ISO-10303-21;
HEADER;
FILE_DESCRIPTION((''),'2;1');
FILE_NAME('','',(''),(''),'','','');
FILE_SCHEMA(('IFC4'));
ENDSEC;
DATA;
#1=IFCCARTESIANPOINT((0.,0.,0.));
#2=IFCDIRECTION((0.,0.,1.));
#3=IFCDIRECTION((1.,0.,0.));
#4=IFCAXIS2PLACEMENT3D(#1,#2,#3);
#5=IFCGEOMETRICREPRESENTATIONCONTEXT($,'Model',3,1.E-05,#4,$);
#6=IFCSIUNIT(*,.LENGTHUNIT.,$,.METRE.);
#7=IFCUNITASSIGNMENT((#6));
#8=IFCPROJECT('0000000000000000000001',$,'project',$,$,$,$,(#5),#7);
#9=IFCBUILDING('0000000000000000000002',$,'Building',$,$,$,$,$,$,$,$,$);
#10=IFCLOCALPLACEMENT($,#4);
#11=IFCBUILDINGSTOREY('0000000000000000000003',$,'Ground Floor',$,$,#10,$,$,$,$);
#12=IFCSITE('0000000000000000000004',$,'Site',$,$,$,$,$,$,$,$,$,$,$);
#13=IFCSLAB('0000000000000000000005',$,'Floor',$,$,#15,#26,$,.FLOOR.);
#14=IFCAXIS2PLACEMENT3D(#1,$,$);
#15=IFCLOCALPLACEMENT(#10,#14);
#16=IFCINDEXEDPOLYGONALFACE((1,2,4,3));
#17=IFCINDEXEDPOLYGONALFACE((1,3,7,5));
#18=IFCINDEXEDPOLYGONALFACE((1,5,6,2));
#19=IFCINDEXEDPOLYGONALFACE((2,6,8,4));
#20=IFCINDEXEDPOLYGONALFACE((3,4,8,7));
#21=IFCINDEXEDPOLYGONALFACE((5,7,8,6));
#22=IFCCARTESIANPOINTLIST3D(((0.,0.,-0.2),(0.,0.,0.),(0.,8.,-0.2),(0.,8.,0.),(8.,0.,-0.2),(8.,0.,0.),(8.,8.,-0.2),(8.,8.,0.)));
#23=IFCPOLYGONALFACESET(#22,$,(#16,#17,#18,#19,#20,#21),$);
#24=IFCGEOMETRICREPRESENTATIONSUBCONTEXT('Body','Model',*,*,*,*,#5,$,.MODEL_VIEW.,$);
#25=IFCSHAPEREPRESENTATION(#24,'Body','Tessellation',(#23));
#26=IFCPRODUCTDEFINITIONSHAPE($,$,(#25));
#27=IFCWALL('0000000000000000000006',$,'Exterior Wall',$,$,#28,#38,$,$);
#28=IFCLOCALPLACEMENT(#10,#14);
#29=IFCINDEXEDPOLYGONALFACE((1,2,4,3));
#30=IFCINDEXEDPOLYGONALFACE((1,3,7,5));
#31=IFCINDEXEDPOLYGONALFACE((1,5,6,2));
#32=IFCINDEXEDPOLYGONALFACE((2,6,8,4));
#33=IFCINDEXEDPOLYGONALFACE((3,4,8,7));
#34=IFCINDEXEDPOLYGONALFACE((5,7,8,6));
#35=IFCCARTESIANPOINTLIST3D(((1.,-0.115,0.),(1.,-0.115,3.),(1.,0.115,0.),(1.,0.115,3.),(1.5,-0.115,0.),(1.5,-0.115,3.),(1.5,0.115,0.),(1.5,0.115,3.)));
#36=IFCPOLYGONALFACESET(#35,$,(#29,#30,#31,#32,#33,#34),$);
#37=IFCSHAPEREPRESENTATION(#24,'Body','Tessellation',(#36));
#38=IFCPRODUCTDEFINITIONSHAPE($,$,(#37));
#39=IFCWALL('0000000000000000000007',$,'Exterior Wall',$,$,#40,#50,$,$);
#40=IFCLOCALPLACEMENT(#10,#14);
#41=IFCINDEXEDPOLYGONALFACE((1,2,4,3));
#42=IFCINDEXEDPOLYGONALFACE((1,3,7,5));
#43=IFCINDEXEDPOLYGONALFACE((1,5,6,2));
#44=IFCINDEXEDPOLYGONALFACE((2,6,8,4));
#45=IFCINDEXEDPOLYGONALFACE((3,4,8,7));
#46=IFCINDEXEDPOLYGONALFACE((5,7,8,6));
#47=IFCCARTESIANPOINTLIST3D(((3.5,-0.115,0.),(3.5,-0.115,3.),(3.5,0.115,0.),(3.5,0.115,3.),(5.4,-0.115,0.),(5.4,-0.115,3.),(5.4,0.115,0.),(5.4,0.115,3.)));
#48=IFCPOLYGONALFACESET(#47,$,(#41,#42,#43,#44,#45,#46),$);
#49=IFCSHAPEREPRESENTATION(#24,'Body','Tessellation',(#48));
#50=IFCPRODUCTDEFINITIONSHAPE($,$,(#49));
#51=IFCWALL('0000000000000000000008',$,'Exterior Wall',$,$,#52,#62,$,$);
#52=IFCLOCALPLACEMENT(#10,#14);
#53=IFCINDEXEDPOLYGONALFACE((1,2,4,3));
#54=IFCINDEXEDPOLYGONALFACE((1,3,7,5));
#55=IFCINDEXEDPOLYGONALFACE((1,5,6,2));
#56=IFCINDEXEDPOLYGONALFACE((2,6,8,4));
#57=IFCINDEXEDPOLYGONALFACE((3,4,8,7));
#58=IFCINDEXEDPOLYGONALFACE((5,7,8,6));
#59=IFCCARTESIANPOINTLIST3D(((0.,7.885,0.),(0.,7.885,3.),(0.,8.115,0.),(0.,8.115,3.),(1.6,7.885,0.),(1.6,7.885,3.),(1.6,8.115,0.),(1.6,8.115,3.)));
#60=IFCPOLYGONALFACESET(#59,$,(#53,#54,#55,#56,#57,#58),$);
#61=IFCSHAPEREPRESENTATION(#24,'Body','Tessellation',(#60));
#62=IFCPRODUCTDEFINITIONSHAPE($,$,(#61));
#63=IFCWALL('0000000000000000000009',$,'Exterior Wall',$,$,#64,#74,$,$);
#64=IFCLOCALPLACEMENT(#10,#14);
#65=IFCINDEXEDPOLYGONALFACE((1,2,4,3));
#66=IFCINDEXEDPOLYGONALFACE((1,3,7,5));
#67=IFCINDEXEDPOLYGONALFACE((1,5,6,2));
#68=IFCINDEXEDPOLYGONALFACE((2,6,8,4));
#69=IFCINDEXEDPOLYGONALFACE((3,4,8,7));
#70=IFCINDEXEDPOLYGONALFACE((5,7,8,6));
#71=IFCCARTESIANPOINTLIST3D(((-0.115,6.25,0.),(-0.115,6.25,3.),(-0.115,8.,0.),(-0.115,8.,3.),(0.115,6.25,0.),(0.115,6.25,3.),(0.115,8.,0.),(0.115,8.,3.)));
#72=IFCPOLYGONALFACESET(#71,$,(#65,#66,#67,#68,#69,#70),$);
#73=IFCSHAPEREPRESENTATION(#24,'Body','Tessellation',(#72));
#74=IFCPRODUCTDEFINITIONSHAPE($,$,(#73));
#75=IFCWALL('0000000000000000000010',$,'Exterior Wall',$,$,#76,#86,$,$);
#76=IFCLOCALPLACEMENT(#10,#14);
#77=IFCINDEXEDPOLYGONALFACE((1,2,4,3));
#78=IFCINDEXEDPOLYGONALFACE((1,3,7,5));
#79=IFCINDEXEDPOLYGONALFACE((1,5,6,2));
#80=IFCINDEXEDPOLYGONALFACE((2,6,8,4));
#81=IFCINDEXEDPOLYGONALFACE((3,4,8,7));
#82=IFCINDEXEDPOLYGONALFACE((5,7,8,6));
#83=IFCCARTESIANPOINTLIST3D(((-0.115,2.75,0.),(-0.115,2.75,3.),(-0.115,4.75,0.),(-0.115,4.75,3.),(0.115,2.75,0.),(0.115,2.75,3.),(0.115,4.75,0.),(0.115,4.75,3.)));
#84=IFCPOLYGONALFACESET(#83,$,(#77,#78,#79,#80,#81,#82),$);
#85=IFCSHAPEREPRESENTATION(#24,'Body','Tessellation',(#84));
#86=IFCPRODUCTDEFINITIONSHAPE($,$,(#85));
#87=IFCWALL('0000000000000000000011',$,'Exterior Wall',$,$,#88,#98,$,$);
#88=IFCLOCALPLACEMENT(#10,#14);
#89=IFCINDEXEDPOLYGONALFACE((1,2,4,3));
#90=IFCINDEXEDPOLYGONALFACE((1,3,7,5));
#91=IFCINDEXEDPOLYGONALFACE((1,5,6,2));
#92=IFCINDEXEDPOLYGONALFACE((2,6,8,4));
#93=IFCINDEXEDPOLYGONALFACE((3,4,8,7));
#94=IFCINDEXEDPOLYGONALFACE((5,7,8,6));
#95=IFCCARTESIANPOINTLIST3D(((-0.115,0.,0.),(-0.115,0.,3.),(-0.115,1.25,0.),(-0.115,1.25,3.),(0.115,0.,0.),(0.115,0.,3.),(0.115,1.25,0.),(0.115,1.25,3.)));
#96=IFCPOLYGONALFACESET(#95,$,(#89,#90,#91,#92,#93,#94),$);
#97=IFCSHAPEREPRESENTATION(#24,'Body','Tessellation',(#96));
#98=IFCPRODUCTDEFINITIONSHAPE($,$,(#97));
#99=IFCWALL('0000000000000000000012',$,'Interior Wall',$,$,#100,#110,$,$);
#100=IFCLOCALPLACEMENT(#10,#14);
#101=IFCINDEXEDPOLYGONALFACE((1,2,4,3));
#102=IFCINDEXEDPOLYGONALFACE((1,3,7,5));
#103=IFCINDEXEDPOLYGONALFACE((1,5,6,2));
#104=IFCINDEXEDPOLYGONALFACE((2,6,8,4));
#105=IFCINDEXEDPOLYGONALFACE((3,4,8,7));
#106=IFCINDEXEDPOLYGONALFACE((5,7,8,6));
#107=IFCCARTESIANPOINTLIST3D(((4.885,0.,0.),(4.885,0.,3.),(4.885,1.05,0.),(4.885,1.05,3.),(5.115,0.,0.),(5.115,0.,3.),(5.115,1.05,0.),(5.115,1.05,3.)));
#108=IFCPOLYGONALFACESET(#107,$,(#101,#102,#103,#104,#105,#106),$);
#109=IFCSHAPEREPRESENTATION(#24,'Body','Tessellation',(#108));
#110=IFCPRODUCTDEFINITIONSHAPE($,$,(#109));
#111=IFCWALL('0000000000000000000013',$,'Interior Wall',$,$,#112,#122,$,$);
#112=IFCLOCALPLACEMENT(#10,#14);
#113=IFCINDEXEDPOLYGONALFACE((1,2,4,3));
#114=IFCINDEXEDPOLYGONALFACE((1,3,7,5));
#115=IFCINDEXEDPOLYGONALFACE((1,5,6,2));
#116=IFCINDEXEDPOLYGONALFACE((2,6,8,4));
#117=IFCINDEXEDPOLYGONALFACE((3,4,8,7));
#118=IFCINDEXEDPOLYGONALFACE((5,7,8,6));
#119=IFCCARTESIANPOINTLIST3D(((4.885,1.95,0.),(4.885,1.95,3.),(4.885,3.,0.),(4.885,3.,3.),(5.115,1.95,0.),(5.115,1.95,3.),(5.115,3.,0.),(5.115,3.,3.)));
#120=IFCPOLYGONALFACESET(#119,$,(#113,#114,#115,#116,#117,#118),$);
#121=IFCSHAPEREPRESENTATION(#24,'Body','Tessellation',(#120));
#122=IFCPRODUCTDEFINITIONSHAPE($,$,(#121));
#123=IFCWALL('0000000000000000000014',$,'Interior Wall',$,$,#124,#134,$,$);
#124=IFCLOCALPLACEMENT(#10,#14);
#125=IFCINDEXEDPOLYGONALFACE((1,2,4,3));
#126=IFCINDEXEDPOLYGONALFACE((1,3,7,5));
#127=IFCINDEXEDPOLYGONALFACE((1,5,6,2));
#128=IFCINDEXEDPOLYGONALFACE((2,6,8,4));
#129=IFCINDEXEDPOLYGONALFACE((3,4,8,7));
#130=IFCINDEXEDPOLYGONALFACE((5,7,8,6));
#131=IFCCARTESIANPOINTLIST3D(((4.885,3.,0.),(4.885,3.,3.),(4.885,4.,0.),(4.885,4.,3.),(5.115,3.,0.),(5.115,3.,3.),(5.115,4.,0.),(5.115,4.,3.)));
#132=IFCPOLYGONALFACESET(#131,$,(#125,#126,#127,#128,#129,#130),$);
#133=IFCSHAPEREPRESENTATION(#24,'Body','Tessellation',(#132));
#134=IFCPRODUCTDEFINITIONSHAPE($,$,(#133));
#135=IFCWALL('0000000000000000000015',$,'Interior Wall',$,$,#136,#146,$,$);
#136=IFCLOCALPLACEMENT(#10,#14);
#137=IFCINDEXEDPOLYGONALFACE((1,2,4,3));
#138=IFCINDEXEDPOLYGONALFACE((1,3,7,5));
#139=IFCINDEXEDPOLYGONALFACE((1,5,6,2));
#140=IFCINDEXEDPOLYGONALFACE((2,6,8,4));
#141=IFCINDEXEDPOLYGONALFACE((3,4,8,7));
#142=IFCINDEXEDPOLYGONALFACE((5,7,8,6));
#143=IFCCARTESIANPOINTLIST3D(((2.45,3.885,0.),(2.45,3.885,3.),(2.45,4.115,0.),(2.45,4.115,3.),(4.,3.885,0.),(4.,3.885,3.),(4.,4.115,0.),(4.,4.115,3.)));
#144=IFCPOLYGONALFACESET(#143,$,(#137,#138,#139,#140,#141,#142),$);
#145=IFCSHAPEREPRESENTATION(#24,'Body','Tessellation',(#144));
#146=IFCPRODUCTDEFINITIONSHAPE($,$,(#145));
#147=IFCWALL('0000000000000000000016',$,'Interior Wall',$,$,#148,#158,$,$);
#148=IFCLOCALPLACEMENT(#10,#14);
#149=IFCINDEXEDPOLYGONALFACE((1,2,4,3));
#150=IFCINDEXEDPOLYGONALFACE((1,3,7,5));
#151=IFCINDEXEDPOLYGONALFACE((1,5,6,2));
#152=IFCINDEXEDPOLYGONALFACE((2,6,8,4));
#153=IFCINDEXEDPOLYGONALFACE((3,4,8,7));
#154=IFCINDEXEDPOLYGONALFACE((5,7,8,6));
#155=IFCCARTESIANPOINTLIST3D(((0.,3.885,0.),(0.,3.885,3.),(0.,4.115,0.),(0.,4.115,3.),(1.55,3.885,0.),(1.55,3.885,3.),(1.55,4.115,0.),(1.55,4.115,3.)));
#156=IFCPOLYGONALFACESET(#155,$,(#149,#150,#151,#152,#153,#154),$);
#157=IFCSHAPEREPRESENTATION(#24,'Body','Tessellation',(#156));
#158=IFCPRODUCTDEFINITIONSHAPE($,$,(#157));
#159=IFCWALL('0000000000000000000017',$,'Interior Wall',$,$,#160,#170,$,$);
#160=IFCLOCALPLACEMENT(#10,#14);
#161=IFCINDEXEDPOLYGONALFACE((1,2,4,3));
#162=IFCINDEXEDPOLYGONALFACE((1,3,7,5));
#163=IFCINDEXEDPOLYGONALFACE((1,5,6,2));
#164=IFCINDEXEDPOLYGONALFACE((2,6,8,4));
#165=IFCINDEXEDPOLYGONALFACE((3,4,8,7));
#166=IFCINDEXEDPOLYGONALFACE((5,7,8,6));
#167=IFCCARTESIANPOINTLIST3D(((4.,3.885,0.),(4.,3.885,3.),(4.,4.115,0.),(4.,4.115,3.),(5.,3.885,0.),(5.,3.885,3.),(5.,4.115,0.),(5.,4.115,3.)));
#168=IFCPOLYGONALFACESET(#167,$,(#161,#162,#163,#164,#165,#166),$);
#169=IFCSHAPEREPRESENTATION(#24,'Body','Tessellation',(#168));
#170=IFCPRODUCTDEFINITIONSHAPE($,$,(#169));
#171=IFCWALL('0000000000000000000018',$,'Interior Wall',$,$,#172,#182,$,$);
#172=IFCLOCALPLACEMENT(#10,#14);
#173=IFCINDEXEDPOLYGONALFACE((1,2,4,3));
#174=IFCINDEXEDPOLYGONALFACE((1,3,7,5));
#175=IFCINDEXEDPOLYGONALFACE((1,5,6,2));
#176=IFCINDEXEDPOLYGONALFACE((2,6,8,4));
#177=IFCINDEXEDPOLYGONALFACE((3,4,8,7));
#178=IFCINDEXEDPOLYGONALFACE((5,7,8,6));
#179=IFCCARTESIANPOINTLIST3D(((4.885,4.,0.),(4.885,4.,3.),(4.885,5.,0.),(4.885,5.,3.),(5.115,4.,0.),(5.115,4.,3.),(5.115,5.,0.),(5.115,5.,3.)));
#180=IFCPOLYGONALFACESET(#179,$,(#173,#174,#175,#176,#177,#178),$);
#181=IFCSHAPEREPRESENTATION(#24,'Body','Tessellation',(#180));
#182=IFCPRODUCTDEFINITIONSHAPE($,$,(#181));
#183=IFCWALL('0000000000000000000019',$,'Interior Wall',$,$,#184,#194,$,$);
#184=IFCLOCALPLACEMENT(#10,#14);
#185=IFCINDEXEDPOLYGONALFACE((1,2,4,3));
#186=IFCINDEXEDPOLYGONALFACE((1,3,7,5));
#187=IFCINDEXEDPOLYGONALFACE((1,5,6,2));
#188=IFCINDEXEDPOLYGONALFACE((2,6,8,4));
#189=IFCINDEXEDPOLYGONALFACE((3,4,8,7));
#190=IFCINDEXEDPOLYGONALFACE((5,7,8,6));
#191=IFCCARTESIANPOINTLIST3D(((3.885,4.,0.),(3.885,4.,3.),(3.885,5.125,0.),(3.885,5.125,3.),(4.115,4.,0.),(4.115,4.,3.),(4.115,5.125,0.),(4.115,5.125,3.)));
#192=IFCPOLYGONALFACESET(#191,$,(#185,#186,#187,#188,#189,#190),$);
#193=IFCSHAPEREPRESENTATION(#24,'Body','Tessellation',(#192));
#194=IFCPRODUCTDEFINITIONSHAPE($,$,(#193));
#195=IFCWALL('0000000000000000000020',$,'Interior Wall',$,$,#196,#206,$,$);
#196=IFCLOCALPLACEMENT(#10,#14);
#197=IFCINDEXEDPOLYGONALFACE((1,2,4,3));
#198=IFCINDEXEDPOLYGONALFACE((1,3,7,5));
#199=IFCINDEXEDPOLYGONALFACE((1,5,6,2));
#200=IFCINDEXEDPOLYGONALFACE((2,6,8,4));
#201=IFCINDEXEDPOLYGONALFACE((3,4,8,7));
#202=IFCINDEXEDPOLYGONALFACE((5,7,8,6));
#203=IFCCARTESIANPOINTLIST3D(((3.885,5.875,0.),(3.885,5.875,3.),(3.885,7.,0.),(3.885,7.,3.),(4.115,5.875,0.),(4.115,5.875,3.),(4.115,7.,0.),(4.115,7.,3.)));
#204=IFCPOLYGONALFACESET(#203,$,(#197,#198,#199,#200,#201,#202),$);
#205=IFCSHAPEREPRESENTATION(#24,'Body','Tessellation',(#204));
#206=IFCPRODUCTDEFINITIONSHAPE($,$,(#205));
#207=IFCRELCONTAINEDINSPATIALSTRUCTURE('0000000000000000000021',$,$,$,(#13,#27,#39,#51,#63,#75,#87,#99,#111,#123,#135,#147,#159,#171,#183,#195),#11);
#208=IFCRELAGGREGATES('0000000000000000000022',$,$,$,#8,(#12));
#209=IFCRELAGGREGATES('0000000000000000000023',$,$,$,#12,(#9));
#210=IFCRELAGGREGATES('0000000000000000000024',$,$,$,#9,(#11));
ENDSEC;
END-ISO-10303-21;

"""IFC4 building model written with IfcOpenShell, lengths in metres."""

from ifc_helpers import new_model, si_unit, frame, origin_with_axes, place, context, subcontext, project, spatial, indexed_curve, outline, extrude, element, save


model = new_model("IFC4")

# Units and contexts
model_context = context("Model", 3, precision=1e-05, world=origin_with_axes())
body_context = subcontext(model_context, "Body", "Model", "MODEL_VIEW")
ifc_project = project(units=[si_unit("LENGTHUNIT", "METRE")], contexts=[model_context])

# Site, building, storey
site = spatial("IfcSite", under=ifc_project, Name="Site")
building = spatial("IfcBuilding", under=site, Name="Building")
storey_placement = place(None, origin_with_axes())
storey = spatial("IfcBuildingStorey", under=building, at=storey_placement, Name="Ground Floor")

# Slab
slab_placement = place(storey_placement, frame((0.0, 0.0, -0.2), z_axis=(0.0, 0.0, 1.0), x_axis=(1.0, 0.0, 0.0)))
element("IfcSlab", 1, at=slab_placement, inside=storey, Name="Floor", PredefinedType="FLOOR", context=body_context, shape_type="SweptSolid", body=[
    extrude(outline(indexed_curve([(0.0, 0.0), (8.0, 0.0), (8.0, 8.0), (0.0, 8.0)])), None, (0.0, 0.0, 1.0), 0.2),
])

# Walls
wall_1_placement = place(storey_placement, frame((1.0, 0.0, 0.0), z_axis=(0.0, 0.0, 1.0), x_axis=(1.0, 0.0, 0.0)))
element("IfcWall", 2, at=wall_1_placement, inside=storey, Name="Exterior Wall", context=body_context, shape_type="SweptSolid", body=[
    extrude(outline(indexed_curve([(0.0, 0.0), (0.0, 0.23), (0.5, 0.23), (0.5, 0.0), (0.0, 0.0)], self_intersect=False)), frame((0.0, -0.115, 0.0), z_axis=(0.0, 0.0, 1.0), x_axis=(1.0, 0.0, 0.0)), (0.0, 0.0, 1.0), 3.0),
])
wall_2_placement = place(storey_placement, frame((3.5, 0.0, 0.0), z_axis=(0.0, 0.0, 1.0), x_axis=(1.0, 0.0, 0.0)))
element("IfcWall", 3, at=wall_2_placement, inside=storey, Name="Exterior Wall", context=body_context, shape_type="SweptSolid", body=[
    extrude(outline(indexed_curve([(0.0, 0.0), (0.0, 0.23), (1.9, 0.23), (1.9, 0.0), (0.0, 0.0)], self_intersect=False)), frame((0.0, -0.115, 0.0), z_axis=(0.0, 0.0, 1.0), x_axis=(1.0, 0.0, 0.0)), (0.0, 0.0, 1.0), 3.0),
])
wall_3_placement = place(storey_placement, frame((1.6, 8.0, 0.0), z_axis=(0.0, 0.0, 1.0), x_axis=(-1.0, 0.0, 0.0)))
element("IfcWall", 4, at=wall_3_placement, inside=storey, Name="Exterior Wall", context=body_context, shape_type="SweptSolid", body=[
    extrude(outline(indexed_curve([(0.0, 0.0), (0.0, 0.23), (1.6, 0.23), (1.6, 0.0), (0.0, 0.0)], self_intersect=False)), frame((0.0, -0.115, 0.0), z_axis=(0.0, 0.0, 1.0), x_axis=(1.0, 0.0, 0.0)), (0.0, 0.0, 1.0), 3.0),
])
wall_4_placement = place(storey_placement, frame((0.0, 8.0, 0.0), z_axis=(0.0, 0.0, 1.0), x_axis=(0.0, -1.0, 0.0)))
element("IfcWall", 5, at=wall_4_placement, inside=storey, Name="Exterior Wall", context=body_context, shape_type="SweptSolid", body=[
    extrude(outline(indexed_curve([(0.0, 0.0), (0.0, 0.23), (1.75, 0.23), (1.75, 0.0), (0.0, 0.0)], self_intersect=False)), frame((0.0, -0.115, 0.0), z_axis=(0.0, 0.0, 1.0), x_axis=(1.0, 0.0, 0.0)), (0.0, 0.0, 1.0), 3.0),
])
wall_5_placement = place(storey_placement, frame((0.0, 4.75, 0.0), z_axis=(0.0, 0.0, 1.0), x_axis=(0.0, -1.0, 0.0)))
element("IfcWall", 6, at=wall_5_placement, inside=storey, Name="Exterior Wall", context=body_context, shape_type="SweptSolid", body=[
    extrude(outline(indexed_curve([(0.0, 0.0), (0.0, 0.23), (2.0, 0.23), (2.0, 0.0), (0.0, 0.0)], self_intersect=False)), frame((0.0, -0.115, 0.0), z_axis=(0.0, 0.0, 1.0), x_axis=(1.0, 0.0, 0.0)), (0.0, 0.0, 1.0), 3.0),
])
wall_6_placement = place(storey_placement, frame((0.0, 1.25, 0.0), z_axis=(0.0, 0.0, 1.0), x_axis=(0.0, -1.0, 0.0)))
element("IfcWall", 7, at=wall_6_placement, inside=storey, Name="Exterior Wall", context=body_context, shape_type="SweptSolid", body=[
    extrude(outline(indexed_curve([(0.0, 0.0), (0.0, 0.23), (1.25, 0.23), (1.25, 0.0), (0.0, 0.0)], self_intersect=False)), frame((0.0, -0.115, 0.0), z_axis=(0.0, 0.0, 1.0), x_axis=(1.0, 0.0, 0.0)), (0.0, 0.0, 1.0), 3.0),
])
for number, where, z_axis, x_axis, name in (
    (8, (5.0, 0.0, 0.0), (0.0, 0.0, 1.0), (0.0, 1.0, 0.0), "Interior Wall"),
    (9, (5.0, 1.95, 0.0), (0.0, 0.0, 1.0), (0.0, 1.0, 0.0), "Interior Wall"),
):
    element("IfcWall", number, at=place(storey_placement, frame(where, z_axis=z_axis, x_axis=x_axis)), inside=storey, Name=name, context=body_context, shape_type="SweptSolid", body=[
        extrude(outline(indexed_curve([(0.0, 0.0), (0.0, 0.23), (1.05, 0.23), (1.05, 0.0), (0.0, 0.0)], self_intersect=False)), frame((0.0, -0.115, 0.0), z_axis=(0.0, 0.0, 1.0), x_axis=(1.0, 0.0, 0.0)), (0.0, 0.0, 1.0), 3.0),
    ])
wall_7_placement = place(storey_placement, frame((5.0, 3.0, 0.0), z_axis=(0.0, 0.0, 1.0), x_axis=(0.0, 1.0, 0.0)))
element("IfcWall", 10, at=wall_7_placement, inside=storey, Name="Interior Wall", context=body_context, shape_type="SweptSolid", body=[
    extrude(outline(indexed_curve([(0.0, 0.0), (0.0, 0.23), (1.0, 0.23), (1.0, 0.0), (0.0, 0.0)], self_intersect=False)), frame((0.0, -0.115, 0.0), z_axis=(0.0, 0.0, 1.0), x_axis=(1.0, 0.0, 0.0)), (0.0, 0.0, 1.0), 3.0),
])
for number, where, z_axis, x_axis, name in (
    (11, (4.0, 4.0, 0.0), (0.0, 0.0, 1.0), (-1.0, 0.0, 0.0), "Interior Wall"),
    (12, (1.55, 4.0, 0.0), (0.0, 0.0, 1.0), (-1.0, 0.0, 0.0), "Interior Wall"),
):
    element("IfcWall", number, at=place(storey_placement, frame(where, z_axis=z_axis, x_axis=x_axis)), inside=storey, Name=name, context=body_context, shape_type="SweptSolid", body=[
        extrude(outline(indexed_curve([(0.0, 0.0), (0.0, 0.23), (1.55, 0.23), (1.55, 0.0), (0.0, 0.0)], self_intersect=False)), frame((0.0, -0.115, 0.0), z_axis=(0.0, 0.0, 1.0), x_axis=(1.0, 0.0, 0.0)), (0.0, 0.0, 1.0), 3.0),
    ])
for number, where, z_axis, x_axis, name in (
    (13, (5.0, 4.0, 0.0), (0.0, 0.0, 1.0), (-1.0, 0.0, 0.0), "Interior Wall"),
    (14, (5.0, 5.0, 0.0), (0.0, 0.0, 1.0), (0.0, -1.0, 0.0), "Interior Wall"),
):
    element("IfcWall", number, at=place(storey_placement, frame(where, z_axis=z_axis, x_axis=x_axis)), inside=storey, Name=name, context=body_context, shape_type="SweptSolid", body=[
        extrude(outline(indexed_curve([(0.0, 0.0), (0.0, 0.23), (1.0, 0.23), (1.0, 0.0), (0.0, 0.0)], self_intersect=False)), frame((0.0, -0.115, 0.0), z_axis=(0.0, 0.0, 1.0), x_axis=(1.0, 0.0, 0.0)), (0.0, 0.0, 1.0), 3.0),
    ])
for number, where, z_axis, x_axis, name in (
    (15, (4.0, 4.0, 0.0), (0.0, 0.0, 1.0), (0.0, 1.0, 0.0), "Interior Wall"),
    (16, (4.0, 5.875, 0.0), (0.0, 0.0, 1.0), (0.0, 1.0, 0.0), "Interior Wall"),
):
    element("IfcWall", number, at=place(storey_placement, frame(where, z_axis=z_axis, x_axis=x_axis)), inside=storey, Name=name, context=body_context, shape_type="SweptSolid", body=[
        extrude(outline(indexed_curve([(0.0, 0.0), (0.0, 0.23), (1.125, 0.23), (1.125, 0.0), (0.0, 0.0)], self_intersect=False)), frame((0.0, -0.115, 0.0), z_axis=(0.0, 0.0, 1.0), x_axis=(1.0, 0.0, 0.0)), (0.0, 0.0, 1.0), 3.0),
    ])

save(model, "model.ifc")
